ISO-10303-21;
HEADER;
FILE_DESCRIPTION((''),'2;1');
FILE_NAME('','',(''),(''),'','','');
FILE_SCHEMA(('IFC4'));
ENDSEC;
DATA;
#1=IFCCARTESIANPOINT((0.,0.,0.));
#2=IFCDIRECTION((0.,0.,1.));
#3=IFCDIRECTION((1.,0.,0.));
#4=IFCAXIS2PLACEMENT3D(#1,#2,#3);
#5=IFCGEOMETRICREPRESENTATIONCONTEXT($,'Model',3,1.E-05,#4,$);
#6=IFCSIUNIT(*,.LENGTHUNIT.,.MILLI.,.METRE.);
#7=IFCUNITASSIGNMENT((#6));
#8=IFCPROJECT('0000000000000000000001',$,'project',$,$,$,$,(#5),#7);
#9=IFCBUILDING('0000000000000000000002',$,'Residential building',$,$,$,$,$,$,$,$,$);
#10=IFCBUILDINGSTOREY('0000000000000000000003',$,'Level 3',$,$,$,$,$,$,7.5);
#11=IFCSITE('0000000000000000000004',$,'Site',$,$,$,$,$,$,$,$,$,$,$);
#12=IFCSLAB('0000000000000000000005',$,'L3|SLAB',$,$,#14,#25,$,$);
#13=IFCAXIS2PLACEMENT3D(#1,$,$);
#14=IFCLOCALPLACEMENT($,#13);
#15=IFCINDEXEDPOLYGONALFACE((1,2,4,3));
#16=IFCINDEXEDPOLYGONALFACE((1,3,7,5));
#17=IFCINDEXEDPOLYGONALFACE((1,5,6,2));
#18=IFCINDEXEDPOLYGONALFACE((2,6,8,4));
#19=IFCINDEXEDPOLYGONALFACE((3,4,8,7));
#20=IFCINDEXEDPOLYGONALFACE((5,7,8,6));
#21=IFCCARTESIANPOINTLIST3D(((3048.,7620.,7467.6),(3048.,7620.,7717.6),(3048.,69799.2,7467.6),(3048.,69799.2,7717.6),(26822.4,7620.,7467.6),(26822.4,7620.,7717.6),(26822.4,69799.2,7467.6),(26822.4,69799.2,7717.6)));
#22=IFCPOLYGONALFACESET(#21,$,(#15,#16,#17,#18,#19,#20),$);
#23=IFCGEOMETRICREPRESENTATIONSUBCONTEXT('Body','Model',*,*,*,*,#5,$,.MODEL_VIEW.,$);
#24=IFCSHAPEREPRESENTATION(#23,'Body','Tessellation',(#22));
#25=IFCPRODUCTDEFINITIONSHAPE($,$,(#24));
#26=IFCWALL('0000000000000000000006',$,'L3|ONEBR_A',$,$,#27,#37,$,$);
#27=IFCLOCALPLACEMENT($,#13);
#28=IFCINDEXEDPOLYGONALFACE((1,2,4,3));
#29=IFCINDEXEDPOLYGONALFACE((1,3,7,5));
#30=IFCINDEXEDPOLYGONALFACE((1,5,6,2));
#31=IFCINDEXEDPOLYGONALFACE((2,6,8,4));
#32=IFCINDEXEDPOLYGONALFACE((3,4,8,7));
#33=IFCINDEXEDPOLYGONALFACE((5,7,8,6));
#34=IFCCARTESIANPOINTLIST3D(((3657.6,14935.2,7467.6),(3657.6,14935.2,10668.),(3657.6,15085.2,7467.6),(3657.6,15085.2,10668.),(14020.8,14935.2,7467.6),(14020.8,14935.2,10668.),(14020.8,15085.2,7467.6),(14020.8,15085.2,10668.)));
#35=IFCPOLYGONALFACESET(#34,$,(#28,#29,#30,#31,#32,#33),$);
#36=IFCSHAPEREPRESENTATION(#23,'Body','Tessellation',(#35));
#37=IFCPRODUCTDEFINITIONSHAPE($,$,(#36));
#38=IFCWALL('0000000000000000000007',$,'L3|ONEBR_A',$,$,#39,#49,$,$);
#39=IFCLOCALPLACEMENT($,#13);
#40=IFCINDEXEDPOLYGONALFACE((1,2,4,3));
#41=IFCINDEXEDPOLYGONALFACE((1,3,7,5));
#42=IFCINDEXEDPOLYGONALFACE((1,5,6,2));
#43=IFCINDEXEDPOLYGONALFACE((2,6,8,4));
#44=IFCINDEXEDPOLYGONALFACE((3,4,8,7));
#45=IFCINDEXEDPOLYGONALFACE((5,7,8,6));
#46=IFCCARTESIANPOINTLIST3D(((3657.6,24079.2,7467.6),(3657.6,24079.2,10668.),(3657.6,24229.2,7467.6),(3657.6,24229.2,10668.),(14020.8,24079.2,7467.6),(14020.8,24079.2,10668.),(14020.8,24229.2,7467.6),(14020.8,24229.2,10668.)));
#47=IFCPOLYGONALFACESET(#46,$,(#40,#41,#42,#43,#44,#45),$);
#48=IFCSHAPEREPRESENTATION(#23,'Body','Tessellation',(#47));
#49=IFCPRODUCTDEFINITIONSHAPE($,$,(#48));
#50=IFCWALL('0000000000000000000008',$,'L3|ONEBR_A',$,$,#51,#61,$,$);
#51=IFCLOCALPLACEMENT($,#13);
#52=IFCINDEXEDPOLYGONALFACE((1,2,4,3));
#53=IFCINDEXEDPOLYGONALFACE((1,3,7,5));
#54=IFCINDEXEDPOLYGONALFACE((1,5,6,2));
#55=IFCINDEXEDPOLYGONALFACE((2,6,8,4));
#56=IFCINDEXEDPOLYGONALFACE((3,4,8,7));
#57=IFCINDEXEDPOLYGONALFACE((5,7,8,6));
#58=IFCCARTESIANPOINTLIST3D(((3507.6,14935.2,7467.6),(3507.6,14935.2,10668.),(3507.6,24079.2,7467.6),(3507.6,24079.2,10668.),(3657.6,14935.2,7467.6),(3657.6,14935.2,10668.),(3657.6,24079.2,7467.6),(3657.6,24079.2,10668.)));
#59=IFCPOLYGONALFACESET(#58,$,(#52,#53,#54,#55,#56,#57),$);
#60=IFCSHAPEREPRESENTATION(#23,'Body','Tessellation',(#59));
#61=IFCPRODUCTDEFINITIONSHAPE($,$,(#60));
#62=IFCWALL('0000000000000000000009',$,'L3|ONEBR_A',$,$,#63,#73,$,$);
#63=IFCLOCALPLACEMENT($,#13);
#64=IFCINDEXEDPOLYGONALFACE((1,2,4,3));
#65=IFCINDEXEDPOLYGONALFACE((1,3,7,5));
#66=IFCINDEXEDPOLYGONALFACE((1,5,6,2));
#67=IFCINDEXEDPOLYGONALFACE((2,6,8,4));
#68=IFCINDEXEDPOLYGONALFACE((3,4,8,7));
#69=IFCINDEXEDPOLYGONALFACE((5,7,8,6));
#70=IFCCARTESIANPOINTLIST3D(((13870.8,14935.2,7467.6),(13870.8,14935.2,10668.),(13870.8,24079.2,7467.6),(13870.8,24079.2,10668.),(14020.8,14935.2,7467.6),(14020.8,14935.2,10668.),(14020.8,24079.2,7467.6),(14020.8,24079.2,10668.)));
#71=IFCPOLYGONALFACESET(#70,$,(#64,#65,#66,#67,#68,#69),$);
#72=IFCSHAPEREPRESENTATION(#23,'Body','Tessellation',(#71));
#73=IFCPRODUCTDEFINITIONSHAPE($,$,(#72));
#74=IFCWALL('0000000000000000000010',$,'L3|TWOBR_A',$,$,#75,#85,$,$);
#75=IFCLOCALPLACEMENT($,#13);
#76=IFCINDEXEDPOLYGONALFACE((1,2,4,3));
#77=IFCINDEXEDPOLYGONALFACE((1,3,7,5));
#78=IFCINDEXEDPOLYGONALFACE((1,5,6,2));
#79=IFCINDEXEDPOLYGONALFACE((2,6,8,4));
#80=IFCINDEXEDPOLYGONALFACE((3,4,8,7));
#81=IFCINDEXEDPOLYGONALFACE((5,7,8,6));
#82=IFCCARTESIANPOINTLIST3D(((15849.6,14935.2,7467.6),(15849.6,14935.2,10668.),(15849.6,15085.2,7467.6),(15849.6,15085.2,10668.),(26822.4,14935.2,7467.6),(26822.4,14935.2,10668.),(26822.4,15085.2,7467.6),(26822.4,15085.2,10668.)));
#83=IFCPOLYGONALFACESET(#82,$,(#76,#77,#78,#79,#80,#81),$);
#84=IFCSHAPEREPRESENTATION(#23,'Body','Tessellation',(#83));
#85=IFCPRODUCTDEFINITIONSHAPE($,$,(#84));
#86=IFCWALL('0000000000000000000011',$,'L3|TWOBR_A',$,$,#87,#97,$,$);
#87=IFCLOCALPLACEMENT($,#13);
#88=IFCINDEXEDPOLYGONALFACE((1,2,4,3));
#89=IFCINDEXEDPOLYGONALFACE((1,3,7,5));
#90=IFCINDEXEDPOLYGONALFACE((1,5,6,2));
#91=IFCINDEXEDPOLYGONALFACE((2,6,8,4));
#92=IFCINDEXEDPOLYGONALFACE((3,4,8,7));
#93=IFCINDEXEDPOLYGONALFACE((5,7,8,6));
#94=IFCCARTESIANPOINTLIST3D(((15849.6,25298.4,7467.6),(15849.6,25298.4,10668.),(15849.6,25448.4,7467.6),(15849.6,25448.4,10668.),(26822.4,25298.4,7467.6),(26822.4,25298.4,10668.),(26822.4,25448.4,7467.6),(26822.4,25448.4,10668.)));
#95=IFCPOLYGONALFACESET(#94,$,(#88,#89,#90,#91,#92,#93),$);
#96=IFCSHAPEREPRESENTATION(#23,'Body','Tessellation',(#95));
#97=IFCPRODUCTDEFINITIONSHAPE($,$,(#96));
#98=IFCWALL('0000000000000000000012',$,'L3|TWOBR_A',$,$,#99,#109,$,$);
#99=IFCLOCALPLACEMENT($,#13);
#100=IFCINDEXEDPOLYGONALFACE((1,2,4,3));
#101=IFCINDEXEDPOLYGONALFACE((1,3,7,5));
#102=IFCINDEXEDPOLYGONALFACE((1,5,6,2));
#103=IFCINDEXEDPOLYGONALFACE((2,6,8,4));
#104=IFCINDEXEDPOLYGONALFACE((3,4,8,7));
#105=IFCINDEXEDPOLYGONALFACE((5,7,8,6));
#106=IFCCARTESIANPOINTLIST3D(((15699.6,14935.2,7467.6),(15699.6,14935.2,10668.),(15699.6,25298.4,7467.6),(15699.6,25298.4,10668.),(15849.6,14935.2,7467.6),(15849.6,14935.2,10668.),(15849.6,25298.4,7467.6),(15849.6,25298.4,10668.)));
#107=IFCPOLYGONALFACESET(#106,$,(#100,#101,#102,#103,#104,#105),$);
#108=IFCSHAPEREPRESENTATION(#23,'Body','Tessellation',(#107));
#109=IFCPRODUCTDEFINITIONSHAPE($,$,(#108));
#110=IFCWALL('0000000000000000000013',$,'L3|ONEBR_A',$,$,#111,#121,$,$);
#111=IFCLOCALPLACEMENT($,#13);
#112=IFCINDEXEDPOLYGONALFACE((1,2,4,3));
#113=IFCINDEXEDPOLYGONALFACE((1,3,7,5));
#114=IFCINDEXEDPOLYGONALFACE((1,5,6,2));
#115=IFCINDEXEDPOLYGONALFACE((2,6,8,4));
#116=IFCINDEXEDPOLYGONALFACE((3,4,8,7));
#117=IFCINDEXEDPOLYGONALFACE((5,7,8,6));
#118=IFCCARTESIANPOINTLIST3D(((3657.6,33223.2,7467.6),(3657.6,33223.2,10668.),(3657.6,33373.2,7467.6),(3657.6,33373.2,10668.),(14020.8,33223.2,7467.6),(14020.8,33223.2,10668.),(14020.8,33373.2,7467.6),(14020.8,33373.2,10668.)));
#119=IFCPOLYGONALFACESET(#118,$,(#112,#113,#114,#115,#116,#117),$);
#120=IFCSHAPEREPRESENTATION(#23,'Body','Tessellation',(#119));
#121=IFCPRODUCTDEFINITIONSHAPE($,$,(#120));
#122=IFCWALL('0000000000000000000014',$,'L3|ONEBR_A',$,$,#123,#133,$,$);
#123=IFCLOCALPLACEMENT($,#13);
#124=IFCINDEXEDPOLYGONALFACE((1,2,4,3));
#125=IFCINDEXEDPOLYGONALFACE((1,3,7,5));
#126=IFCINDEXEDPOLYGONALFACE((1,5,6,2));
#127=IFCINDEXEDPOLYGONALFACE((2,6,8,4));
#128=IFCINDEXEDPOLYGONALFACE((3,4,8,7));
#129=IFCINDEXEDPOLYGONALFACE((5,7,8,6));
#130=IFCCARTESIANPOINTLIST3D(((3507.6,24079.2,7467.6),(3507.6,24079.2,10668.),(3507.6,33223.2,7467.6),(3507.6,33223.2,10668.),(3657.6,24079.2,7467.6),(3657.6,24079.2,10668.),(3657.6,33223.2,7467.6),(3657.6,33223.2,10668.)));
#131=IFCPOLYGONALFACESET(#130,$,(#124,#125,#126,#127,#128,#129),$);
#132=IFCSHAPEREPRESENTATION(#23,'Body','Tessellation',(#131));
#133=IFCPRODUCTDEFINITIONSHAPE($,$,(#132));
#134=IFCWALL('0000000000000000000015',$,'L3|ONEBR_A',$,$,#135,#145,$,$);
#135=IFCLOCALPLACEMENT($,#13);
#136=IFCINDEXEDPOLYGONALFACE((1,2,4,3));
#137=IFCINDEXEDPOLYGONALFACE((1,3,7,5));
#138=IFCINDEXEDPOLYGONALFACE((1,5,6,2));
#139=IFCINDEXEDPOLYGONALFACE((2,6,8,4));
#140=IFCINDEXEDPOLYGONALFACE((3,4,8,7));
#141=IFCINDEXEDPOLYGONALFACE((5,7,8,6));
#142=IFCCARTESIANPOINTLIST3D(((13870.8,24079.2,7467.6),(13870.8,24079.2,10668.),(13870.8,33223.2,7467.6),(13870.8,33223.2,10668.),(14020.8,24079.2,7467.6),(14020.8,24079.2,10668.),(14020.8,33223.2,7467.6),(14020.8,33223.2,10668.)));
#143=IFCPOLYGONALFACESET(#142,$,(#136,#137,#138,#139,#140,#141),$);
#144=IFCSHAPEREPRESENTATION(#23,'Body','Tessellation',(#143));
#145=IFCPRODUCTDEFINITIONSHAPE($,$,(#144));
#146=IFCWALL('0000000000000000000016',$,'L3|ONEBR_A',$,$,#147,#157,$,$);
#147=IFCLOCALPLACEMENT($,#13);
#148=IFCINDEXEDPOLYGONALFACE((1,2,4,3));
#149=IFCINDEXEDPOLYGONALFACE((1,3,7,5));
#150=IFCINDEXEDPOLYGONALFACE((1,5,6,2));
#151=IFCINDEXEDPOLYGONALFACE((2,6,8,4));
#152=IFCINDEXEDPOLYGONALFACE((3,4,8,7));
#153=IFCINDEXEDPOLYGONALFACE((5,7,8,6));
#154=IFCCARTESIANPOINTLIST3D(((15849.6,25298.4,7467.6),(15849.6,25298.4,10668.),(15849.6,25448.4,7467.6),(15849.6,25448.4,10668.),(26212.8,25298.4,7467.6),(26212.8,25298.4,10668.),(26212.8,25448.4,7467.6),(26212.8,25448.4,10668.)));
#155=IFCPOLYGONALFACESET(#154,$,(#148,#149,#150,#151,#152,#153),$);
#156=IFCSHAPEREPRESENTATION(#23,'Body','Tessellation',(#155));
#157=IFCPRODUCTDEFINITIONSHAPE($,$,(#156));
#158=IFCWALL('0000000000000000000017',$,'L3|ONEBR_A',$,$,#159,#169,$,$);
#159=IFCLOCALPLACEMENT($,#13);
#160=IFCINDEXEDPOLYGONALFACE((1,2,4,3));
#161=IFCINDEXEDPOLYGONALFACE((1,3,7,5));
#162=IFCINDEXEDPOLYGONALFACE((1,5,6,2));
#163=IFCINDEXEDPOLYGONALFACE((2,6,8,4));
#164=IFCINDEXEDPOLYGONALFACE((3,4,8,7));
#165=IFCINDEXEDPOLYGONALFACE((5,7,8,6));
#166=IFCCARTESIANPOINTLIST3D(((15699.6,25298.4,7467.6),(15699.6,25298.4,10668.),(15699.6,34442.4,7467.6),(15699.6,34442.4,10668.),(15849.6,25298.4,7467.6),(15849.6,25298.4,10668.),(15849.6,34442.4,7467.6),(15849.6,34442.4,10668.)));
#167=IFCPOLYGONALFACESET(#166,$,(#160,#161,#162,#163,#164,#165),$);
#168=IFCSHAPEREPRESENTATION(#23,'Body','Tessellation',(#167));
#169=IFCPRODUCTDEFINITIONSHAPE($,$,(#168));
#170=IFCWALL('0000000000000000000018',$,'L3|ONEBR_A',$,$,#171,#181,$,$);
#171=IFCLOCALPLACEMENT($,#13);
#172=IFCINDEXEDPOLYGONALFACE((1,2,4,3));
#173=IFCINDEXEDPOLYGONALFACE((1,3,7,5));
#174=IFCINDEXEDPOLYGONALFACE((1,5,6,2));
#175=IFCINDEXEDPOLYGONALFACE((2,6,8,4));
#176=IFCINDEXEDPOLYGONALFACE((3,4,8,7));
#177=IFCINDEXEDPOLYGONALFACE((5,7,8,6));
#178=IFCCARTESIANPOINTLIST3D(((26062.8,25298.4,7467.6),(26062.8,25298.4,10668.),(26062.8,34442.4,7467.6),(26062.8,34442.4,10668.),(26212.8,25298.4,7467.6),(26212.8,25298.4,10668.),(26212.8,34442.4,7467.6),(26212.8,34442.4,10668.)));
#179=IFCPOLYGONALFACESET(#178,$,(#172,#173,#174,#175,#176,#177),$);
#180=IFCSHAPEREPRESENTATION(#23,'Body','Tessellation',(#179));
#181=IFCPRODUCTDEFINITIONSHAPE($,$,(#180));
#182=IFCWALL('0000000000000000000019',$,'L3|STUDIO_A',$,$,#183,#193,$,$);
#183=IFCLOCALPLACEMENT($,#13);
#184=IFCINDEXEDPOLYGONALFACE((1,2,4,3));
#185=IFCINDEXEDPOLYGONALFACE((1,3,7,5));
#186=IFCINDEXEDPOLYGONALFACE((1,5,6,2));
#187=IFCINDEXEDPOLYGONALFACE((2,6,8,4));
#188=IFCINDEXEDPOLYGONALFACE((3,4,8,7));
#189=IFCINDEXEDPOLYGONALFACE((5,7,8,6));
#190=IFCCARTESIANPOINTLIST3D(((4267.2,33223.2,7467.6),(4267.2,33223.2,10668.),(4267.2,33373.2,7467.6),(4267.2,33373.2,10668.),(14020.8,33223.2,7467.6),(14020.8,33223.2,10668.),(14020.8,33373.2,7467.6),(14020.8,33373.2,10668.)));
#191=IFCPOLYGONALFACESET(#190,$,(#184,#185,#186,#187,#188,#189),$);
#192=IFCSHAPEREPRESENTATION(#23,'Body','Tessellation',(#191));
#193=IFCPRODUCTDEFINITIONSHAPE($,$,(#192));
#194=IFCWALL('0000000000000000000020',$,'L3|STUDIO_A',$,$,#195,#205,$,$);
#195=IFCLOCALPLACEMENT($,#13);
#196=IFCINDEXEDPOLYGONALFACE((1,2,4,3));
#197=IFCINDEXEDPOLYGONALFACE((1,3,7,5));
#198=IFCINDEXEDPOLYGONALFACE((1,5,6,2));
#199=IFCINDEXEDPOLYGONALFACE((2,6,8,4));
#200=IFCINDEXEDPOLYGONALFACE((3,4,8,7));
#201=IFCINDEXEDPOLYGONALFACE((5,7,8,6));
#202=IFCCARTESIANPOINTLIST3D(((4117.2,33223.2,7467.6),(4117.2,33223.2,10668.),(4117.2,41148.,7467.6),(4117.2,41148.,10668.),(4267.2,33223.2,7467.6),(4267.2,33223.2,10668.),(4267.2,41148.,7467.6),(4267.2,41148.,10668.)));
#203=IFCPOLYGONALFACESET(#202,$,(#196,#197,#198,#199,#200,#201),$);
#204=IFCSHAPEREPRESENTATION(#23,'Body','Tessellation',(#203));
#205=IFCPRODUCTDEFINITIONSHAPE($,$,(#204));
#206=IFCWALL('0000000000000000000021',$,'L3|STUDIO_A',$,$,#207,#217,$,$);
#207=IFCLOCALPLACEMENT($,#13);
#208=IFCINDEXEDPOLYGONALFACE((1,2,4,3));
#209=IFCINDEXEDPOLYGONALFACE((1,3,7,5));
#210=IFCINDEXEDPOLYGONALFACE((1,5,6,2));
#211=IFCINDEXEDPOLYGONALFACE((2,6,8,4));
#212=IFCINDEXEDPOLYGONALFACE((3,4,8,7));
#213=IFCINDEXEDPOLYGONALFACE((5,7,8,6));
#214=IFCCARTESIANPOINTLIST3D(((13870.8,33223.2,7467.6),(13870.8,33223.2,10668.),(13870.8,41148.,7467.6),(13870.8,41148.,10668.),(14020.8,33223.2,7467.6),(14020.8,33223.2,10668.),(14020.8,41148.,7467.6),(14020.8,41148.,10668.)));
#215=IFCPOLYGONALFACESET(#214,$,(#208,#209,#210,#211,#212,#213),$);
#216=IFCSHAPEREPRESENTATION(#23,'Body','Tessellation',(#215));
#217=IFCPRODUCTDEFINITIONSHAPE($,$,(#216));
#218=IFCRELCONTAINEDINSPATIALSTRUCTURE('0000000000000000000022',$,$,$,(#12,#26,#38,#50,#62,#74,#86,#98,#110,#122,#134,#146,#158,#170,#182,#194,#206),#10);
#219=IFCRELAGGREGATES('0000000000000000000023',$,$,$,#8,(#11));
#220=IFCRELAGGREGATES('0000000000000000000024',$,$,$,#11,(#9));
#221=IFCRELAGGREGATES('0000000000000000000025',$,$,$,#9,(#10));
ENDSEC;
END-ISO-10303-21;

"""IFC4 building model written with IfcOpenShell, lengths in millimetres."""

from ifc_helpers import new_model, si_unit, frame, origin_with_axes, place, context, subcontext, project, spatial, indexed_curve, outline, extrude, element, save


model = new_model("IFC4")

# Units and contexts
model_context = context("Model", 3, precision=1e-05, world=origin_with_axes())
body_context = subcontext(model_context, "Body", "Model", "MODEL_VIEW")
ifc_project = project(units=[si_unit("LENGTHUNIT", "METRE", prefix="MILLI")], contexts=[model_context])

# Site, building, storey
site = spatial("IfcSite", under=ifc_project, Name="Site")
building = spatial("IfcBuilding", under=site, Name="Residential building")
storey = spatial("IfcBuildingStorey", under=building, Name="Level 3", Elevation=7.5)

# Slab
slab_placement = place(None, frame((3048.0, 7620.0, 7467.6), z_axis=(0.0, 0.0, 1.0), x_axis=(1.0, 0.0, 0.0)))
element("IfcSlab", 1, at=slab_placement, inside=storey, Name="L3|SLAB", context=body_context, shape_type="SweptSolid", body=[
    extrude(outline(indexed_curve([(0.0, 0.0), (23774.4, 0.0), (23774.4, 62179.2), (0.0, 62179.2), (0.0, 0.0)])), None, (0.0, 0.0, 1.0), 250.0),
])

# Walls
for number, where, z_axis, x_axis, name in (
    (2, (3657.6, 14935.2, 7467.6), (0.0, 0.0, 1.0), (1.0, 0.0, 0.0), "L3|ONEBR_A"),
    (3, (3657.6, 24079.2, 7467.6), (0.0, 0.0, 1.0), (1.0, 0.0, 0.0), "L3|ONEBR_A"),
):
    element("IfcWall", number, at=place(None, frame(where, z_axis=z_axis, x_axis=x_axis)), inside=storey, Name=name, context=body_context, shape_type="SweptSolid", body=[
        extrude(outline(indexed_curve([(0.0, 0.0), (0.0, 150.0), (10363.2, 150.0), (10363.2, 0.0), (0.0, 0.0)], self_intersect=False)), origin_with_axes(), (0.0, 0.0, 1.0), 3200.4),
    ])
for number, where, z_axis, x_axis, name in (
    (4, (3657.6, 14935.2, 7467.6), (0.0, 0.0, 1.0), (0.0, 1.0, 0.0), "L3|ONEBR_A"),
    (5, (14020.8, 14935.2, 7467.6), (0.0, 0.0, 1.0), (0.0, 1.0, 0.0), "L3|ONEBR_A"),
):
    element("IfcWall", number, at=place(None, frame(where, z_axis=z_axis, x_axis=x_axis)), inside=storey, Name=name, context=body_context, shape_type="SweptSolid", body=[
        extrude(outline(indexed_curve([(0.0, 0.0), (0.0, 150.0), (9144.0, 150.0), (9144.0, 0.0), (0.0, 0.0)], self_intersect=False)), origin_with_axes(), (0.0, 0.0, 1.0), 3200.4),
    ])
for number, where, z_axis, x_axis, name in (
    (6, (15849.6, 14935.2, 7467.6), (0.0, 0.0, 1.0), (1.0, 0.0, 0.0), "L3|TWOBR_A"),
    (7, (15849.6, 25298.4, 7467.6), (0.0, 0.0, 1.0), (1.0, 0.0, 0.0), "L3|TWOBR_A"),
):
    element("IfcWall", number, at=place(None, frame(where, z_axis=z_axis, x_axis=x_axis)), inside=storey, Name=name, context=body_context, shape_type="SweptSolid", body=[
        extrude(outline(indexed_curve([(0.0, 0.0), (0.0, 150.0), (10972.8, 150.0), (10972.8, 0.0), (0.0, 0.0)], self_intersect=False)), origin_with_axes(), (0.0, 0.0, 1.0), 3200.4),
    ])
for number, where, z_axis, x_axis, name in (
    (8, (15849.6, 14935.2, 7467.6), (0.0, 0.0, 1.0), (0.0, 1.0, 0.0), "L3|TWOBR_A"),
    (9, (3657.6, 33223.2, 7467.6), (0.0, 0.0, 1.0), (1.0, 0.0, 0.0), "L3|ONEBR_A"),
):
    element("IfcWall", number, at=place(None, frame(where, z_axis=z_axis, x_axis=x_axis)), inside=storey, Name=name, context=body_context, shape_type="SweptSolid", body=[
        extrude(outline(indexed_curve([(0.0, 0.0), (0.0, 150.0), (10363.2, 150.0), (10363.2, 0.0), (0.0, 0.0)], self_intersect=False)), origin_with_axes(), (0.0, 0.0, 1.0), 3200.4),
    ])
for number, where, z_axis, x_axis, name in (
    (10, (3657.6, 24079.2, 7467.6), (0.0, 0.0, 1.0), (0.0, 1.0, 0.0), "L3|ONEBR_A"),
    (11, (14020.8, 24079.2, 7467.6), (0.0, 0.0, 1.0), (0.0, 1.0, 0.0), "L3|ONEBR_A"),
):
    element("IfcWall", number, at=place(None, frame(where, z_axis=z_axis, x_axis=x_axis)), inside=storey, Name=name, context=body_context, shape_type="SweptSolid", body=[
        extrude(outline(indexed_curve([(0.0, 0.0), (0.0, 150.0), (9144.0, 150.0), (9144.0, 0.0), (0.0, 0.0)], self_intersect=False)), origin_with_axes(), (0.0, 0.0, 1.0), 3200.4),
    ])
wall_1_placement = place(None, frame((15849.6, 25298.4, 7467.6), z_axis=(0.0, 0.0, 1.0), x_axis=(1.0, 0.0, 0.0)))
element("IfcWall", 12, at=wall_1_placement, inside=storey, Name="L3|ONEBR_A", context=body_context, shape_type="SweptSolid", body=[
    extrude(outline(indexed_curve([(0.0, 0.0), (0.0, 150.0), (10363.2, 150.0), (10363.2, 0.0), (0.0, 0.0)], self_intersect=False)), origin_with_axes(), (0.0, 0.0, 1.0), 3200.4),
])
for number, where, z_axis, x_axis, name in (
    (13, (15849.6, 25298.4, 7467.6), (0.0, 0.0, 1.0), (0.0, 1.0, 0.0), "L3|ONEBR_A"),
    (14, (26212.8, 25298.4, 7467.6), (0.0, 0.0, 1.0), (0.0, 1.0, 0.0), "L3|ONEBR_A"),
):
    element("IfcWall", number, at=place(None, frame(where, z_axis=z_axis, x_axis=x_axis)), inside=storey, Name=name, context=body_context, shape_type="SweptSolid", body=[
        extrude(outline(indexed_curve([(0.0, 0.0), (0.0, 150.0), (9144.0, 150.0), (9144.0, 0.0), (0.0, 0.0)], self_intersect=False)), origin_with_axes(), (0.0, 0.0, 1.0), 3200.4),
    ])
wall_2_placement = place(None, frame((4267.2, 33223.2, 7467.6), z_axis=(0.0, 0.0, 1.0), x_axis=(1.0, 0.0, 0.0)))
element("IfcWall", 15, at=wall_2_placement, inside=storey, Name="L3|STUDIO_A", context=body_context, shape_type="SweptSolid", body=[
    extrude(outline(indexed_curve([(0.0, 0.0), (0.0, 150.0), (9753.6, 150.0), (9753.6, 0.0), (0.0, 0.0)], self_intersect=False)), origin_with_axes(), (0.0, 0.0, 1.0), 3200.4),
])
for number, where, z_axis, x_axis, name in (
    (16, (4267.2, 33223.2, 7467.6), (0.0, 0.0, 1.0), (0.0, 1.0, 0.0), "L3|STUDIO_A"),
    (17, (14020.8, 33223.2, 7467.6), (0.0, 0.0, 1.0), (0.0, 1.0, 0.0), "L3|STUDIO_A"),
):
    element("IfcWall", number, at=place(None, frame(where, z_axis=z_axis, x_axis=x_axis)), inside=storey, Name=name, context=body_context, shape_type="SweptSolid", body=[
        extrude(outline(indexed_curve([(0.0, 0.0), (0.0, 150.0), (7924.8, 150.0), (7924.8, 0.0), (0.0, 0.0)], self_intersect=False)), origin_with_axes(), (0.0, 0.0, 1.0), 3200.4),
    ])

save(model, "model.ifc")
